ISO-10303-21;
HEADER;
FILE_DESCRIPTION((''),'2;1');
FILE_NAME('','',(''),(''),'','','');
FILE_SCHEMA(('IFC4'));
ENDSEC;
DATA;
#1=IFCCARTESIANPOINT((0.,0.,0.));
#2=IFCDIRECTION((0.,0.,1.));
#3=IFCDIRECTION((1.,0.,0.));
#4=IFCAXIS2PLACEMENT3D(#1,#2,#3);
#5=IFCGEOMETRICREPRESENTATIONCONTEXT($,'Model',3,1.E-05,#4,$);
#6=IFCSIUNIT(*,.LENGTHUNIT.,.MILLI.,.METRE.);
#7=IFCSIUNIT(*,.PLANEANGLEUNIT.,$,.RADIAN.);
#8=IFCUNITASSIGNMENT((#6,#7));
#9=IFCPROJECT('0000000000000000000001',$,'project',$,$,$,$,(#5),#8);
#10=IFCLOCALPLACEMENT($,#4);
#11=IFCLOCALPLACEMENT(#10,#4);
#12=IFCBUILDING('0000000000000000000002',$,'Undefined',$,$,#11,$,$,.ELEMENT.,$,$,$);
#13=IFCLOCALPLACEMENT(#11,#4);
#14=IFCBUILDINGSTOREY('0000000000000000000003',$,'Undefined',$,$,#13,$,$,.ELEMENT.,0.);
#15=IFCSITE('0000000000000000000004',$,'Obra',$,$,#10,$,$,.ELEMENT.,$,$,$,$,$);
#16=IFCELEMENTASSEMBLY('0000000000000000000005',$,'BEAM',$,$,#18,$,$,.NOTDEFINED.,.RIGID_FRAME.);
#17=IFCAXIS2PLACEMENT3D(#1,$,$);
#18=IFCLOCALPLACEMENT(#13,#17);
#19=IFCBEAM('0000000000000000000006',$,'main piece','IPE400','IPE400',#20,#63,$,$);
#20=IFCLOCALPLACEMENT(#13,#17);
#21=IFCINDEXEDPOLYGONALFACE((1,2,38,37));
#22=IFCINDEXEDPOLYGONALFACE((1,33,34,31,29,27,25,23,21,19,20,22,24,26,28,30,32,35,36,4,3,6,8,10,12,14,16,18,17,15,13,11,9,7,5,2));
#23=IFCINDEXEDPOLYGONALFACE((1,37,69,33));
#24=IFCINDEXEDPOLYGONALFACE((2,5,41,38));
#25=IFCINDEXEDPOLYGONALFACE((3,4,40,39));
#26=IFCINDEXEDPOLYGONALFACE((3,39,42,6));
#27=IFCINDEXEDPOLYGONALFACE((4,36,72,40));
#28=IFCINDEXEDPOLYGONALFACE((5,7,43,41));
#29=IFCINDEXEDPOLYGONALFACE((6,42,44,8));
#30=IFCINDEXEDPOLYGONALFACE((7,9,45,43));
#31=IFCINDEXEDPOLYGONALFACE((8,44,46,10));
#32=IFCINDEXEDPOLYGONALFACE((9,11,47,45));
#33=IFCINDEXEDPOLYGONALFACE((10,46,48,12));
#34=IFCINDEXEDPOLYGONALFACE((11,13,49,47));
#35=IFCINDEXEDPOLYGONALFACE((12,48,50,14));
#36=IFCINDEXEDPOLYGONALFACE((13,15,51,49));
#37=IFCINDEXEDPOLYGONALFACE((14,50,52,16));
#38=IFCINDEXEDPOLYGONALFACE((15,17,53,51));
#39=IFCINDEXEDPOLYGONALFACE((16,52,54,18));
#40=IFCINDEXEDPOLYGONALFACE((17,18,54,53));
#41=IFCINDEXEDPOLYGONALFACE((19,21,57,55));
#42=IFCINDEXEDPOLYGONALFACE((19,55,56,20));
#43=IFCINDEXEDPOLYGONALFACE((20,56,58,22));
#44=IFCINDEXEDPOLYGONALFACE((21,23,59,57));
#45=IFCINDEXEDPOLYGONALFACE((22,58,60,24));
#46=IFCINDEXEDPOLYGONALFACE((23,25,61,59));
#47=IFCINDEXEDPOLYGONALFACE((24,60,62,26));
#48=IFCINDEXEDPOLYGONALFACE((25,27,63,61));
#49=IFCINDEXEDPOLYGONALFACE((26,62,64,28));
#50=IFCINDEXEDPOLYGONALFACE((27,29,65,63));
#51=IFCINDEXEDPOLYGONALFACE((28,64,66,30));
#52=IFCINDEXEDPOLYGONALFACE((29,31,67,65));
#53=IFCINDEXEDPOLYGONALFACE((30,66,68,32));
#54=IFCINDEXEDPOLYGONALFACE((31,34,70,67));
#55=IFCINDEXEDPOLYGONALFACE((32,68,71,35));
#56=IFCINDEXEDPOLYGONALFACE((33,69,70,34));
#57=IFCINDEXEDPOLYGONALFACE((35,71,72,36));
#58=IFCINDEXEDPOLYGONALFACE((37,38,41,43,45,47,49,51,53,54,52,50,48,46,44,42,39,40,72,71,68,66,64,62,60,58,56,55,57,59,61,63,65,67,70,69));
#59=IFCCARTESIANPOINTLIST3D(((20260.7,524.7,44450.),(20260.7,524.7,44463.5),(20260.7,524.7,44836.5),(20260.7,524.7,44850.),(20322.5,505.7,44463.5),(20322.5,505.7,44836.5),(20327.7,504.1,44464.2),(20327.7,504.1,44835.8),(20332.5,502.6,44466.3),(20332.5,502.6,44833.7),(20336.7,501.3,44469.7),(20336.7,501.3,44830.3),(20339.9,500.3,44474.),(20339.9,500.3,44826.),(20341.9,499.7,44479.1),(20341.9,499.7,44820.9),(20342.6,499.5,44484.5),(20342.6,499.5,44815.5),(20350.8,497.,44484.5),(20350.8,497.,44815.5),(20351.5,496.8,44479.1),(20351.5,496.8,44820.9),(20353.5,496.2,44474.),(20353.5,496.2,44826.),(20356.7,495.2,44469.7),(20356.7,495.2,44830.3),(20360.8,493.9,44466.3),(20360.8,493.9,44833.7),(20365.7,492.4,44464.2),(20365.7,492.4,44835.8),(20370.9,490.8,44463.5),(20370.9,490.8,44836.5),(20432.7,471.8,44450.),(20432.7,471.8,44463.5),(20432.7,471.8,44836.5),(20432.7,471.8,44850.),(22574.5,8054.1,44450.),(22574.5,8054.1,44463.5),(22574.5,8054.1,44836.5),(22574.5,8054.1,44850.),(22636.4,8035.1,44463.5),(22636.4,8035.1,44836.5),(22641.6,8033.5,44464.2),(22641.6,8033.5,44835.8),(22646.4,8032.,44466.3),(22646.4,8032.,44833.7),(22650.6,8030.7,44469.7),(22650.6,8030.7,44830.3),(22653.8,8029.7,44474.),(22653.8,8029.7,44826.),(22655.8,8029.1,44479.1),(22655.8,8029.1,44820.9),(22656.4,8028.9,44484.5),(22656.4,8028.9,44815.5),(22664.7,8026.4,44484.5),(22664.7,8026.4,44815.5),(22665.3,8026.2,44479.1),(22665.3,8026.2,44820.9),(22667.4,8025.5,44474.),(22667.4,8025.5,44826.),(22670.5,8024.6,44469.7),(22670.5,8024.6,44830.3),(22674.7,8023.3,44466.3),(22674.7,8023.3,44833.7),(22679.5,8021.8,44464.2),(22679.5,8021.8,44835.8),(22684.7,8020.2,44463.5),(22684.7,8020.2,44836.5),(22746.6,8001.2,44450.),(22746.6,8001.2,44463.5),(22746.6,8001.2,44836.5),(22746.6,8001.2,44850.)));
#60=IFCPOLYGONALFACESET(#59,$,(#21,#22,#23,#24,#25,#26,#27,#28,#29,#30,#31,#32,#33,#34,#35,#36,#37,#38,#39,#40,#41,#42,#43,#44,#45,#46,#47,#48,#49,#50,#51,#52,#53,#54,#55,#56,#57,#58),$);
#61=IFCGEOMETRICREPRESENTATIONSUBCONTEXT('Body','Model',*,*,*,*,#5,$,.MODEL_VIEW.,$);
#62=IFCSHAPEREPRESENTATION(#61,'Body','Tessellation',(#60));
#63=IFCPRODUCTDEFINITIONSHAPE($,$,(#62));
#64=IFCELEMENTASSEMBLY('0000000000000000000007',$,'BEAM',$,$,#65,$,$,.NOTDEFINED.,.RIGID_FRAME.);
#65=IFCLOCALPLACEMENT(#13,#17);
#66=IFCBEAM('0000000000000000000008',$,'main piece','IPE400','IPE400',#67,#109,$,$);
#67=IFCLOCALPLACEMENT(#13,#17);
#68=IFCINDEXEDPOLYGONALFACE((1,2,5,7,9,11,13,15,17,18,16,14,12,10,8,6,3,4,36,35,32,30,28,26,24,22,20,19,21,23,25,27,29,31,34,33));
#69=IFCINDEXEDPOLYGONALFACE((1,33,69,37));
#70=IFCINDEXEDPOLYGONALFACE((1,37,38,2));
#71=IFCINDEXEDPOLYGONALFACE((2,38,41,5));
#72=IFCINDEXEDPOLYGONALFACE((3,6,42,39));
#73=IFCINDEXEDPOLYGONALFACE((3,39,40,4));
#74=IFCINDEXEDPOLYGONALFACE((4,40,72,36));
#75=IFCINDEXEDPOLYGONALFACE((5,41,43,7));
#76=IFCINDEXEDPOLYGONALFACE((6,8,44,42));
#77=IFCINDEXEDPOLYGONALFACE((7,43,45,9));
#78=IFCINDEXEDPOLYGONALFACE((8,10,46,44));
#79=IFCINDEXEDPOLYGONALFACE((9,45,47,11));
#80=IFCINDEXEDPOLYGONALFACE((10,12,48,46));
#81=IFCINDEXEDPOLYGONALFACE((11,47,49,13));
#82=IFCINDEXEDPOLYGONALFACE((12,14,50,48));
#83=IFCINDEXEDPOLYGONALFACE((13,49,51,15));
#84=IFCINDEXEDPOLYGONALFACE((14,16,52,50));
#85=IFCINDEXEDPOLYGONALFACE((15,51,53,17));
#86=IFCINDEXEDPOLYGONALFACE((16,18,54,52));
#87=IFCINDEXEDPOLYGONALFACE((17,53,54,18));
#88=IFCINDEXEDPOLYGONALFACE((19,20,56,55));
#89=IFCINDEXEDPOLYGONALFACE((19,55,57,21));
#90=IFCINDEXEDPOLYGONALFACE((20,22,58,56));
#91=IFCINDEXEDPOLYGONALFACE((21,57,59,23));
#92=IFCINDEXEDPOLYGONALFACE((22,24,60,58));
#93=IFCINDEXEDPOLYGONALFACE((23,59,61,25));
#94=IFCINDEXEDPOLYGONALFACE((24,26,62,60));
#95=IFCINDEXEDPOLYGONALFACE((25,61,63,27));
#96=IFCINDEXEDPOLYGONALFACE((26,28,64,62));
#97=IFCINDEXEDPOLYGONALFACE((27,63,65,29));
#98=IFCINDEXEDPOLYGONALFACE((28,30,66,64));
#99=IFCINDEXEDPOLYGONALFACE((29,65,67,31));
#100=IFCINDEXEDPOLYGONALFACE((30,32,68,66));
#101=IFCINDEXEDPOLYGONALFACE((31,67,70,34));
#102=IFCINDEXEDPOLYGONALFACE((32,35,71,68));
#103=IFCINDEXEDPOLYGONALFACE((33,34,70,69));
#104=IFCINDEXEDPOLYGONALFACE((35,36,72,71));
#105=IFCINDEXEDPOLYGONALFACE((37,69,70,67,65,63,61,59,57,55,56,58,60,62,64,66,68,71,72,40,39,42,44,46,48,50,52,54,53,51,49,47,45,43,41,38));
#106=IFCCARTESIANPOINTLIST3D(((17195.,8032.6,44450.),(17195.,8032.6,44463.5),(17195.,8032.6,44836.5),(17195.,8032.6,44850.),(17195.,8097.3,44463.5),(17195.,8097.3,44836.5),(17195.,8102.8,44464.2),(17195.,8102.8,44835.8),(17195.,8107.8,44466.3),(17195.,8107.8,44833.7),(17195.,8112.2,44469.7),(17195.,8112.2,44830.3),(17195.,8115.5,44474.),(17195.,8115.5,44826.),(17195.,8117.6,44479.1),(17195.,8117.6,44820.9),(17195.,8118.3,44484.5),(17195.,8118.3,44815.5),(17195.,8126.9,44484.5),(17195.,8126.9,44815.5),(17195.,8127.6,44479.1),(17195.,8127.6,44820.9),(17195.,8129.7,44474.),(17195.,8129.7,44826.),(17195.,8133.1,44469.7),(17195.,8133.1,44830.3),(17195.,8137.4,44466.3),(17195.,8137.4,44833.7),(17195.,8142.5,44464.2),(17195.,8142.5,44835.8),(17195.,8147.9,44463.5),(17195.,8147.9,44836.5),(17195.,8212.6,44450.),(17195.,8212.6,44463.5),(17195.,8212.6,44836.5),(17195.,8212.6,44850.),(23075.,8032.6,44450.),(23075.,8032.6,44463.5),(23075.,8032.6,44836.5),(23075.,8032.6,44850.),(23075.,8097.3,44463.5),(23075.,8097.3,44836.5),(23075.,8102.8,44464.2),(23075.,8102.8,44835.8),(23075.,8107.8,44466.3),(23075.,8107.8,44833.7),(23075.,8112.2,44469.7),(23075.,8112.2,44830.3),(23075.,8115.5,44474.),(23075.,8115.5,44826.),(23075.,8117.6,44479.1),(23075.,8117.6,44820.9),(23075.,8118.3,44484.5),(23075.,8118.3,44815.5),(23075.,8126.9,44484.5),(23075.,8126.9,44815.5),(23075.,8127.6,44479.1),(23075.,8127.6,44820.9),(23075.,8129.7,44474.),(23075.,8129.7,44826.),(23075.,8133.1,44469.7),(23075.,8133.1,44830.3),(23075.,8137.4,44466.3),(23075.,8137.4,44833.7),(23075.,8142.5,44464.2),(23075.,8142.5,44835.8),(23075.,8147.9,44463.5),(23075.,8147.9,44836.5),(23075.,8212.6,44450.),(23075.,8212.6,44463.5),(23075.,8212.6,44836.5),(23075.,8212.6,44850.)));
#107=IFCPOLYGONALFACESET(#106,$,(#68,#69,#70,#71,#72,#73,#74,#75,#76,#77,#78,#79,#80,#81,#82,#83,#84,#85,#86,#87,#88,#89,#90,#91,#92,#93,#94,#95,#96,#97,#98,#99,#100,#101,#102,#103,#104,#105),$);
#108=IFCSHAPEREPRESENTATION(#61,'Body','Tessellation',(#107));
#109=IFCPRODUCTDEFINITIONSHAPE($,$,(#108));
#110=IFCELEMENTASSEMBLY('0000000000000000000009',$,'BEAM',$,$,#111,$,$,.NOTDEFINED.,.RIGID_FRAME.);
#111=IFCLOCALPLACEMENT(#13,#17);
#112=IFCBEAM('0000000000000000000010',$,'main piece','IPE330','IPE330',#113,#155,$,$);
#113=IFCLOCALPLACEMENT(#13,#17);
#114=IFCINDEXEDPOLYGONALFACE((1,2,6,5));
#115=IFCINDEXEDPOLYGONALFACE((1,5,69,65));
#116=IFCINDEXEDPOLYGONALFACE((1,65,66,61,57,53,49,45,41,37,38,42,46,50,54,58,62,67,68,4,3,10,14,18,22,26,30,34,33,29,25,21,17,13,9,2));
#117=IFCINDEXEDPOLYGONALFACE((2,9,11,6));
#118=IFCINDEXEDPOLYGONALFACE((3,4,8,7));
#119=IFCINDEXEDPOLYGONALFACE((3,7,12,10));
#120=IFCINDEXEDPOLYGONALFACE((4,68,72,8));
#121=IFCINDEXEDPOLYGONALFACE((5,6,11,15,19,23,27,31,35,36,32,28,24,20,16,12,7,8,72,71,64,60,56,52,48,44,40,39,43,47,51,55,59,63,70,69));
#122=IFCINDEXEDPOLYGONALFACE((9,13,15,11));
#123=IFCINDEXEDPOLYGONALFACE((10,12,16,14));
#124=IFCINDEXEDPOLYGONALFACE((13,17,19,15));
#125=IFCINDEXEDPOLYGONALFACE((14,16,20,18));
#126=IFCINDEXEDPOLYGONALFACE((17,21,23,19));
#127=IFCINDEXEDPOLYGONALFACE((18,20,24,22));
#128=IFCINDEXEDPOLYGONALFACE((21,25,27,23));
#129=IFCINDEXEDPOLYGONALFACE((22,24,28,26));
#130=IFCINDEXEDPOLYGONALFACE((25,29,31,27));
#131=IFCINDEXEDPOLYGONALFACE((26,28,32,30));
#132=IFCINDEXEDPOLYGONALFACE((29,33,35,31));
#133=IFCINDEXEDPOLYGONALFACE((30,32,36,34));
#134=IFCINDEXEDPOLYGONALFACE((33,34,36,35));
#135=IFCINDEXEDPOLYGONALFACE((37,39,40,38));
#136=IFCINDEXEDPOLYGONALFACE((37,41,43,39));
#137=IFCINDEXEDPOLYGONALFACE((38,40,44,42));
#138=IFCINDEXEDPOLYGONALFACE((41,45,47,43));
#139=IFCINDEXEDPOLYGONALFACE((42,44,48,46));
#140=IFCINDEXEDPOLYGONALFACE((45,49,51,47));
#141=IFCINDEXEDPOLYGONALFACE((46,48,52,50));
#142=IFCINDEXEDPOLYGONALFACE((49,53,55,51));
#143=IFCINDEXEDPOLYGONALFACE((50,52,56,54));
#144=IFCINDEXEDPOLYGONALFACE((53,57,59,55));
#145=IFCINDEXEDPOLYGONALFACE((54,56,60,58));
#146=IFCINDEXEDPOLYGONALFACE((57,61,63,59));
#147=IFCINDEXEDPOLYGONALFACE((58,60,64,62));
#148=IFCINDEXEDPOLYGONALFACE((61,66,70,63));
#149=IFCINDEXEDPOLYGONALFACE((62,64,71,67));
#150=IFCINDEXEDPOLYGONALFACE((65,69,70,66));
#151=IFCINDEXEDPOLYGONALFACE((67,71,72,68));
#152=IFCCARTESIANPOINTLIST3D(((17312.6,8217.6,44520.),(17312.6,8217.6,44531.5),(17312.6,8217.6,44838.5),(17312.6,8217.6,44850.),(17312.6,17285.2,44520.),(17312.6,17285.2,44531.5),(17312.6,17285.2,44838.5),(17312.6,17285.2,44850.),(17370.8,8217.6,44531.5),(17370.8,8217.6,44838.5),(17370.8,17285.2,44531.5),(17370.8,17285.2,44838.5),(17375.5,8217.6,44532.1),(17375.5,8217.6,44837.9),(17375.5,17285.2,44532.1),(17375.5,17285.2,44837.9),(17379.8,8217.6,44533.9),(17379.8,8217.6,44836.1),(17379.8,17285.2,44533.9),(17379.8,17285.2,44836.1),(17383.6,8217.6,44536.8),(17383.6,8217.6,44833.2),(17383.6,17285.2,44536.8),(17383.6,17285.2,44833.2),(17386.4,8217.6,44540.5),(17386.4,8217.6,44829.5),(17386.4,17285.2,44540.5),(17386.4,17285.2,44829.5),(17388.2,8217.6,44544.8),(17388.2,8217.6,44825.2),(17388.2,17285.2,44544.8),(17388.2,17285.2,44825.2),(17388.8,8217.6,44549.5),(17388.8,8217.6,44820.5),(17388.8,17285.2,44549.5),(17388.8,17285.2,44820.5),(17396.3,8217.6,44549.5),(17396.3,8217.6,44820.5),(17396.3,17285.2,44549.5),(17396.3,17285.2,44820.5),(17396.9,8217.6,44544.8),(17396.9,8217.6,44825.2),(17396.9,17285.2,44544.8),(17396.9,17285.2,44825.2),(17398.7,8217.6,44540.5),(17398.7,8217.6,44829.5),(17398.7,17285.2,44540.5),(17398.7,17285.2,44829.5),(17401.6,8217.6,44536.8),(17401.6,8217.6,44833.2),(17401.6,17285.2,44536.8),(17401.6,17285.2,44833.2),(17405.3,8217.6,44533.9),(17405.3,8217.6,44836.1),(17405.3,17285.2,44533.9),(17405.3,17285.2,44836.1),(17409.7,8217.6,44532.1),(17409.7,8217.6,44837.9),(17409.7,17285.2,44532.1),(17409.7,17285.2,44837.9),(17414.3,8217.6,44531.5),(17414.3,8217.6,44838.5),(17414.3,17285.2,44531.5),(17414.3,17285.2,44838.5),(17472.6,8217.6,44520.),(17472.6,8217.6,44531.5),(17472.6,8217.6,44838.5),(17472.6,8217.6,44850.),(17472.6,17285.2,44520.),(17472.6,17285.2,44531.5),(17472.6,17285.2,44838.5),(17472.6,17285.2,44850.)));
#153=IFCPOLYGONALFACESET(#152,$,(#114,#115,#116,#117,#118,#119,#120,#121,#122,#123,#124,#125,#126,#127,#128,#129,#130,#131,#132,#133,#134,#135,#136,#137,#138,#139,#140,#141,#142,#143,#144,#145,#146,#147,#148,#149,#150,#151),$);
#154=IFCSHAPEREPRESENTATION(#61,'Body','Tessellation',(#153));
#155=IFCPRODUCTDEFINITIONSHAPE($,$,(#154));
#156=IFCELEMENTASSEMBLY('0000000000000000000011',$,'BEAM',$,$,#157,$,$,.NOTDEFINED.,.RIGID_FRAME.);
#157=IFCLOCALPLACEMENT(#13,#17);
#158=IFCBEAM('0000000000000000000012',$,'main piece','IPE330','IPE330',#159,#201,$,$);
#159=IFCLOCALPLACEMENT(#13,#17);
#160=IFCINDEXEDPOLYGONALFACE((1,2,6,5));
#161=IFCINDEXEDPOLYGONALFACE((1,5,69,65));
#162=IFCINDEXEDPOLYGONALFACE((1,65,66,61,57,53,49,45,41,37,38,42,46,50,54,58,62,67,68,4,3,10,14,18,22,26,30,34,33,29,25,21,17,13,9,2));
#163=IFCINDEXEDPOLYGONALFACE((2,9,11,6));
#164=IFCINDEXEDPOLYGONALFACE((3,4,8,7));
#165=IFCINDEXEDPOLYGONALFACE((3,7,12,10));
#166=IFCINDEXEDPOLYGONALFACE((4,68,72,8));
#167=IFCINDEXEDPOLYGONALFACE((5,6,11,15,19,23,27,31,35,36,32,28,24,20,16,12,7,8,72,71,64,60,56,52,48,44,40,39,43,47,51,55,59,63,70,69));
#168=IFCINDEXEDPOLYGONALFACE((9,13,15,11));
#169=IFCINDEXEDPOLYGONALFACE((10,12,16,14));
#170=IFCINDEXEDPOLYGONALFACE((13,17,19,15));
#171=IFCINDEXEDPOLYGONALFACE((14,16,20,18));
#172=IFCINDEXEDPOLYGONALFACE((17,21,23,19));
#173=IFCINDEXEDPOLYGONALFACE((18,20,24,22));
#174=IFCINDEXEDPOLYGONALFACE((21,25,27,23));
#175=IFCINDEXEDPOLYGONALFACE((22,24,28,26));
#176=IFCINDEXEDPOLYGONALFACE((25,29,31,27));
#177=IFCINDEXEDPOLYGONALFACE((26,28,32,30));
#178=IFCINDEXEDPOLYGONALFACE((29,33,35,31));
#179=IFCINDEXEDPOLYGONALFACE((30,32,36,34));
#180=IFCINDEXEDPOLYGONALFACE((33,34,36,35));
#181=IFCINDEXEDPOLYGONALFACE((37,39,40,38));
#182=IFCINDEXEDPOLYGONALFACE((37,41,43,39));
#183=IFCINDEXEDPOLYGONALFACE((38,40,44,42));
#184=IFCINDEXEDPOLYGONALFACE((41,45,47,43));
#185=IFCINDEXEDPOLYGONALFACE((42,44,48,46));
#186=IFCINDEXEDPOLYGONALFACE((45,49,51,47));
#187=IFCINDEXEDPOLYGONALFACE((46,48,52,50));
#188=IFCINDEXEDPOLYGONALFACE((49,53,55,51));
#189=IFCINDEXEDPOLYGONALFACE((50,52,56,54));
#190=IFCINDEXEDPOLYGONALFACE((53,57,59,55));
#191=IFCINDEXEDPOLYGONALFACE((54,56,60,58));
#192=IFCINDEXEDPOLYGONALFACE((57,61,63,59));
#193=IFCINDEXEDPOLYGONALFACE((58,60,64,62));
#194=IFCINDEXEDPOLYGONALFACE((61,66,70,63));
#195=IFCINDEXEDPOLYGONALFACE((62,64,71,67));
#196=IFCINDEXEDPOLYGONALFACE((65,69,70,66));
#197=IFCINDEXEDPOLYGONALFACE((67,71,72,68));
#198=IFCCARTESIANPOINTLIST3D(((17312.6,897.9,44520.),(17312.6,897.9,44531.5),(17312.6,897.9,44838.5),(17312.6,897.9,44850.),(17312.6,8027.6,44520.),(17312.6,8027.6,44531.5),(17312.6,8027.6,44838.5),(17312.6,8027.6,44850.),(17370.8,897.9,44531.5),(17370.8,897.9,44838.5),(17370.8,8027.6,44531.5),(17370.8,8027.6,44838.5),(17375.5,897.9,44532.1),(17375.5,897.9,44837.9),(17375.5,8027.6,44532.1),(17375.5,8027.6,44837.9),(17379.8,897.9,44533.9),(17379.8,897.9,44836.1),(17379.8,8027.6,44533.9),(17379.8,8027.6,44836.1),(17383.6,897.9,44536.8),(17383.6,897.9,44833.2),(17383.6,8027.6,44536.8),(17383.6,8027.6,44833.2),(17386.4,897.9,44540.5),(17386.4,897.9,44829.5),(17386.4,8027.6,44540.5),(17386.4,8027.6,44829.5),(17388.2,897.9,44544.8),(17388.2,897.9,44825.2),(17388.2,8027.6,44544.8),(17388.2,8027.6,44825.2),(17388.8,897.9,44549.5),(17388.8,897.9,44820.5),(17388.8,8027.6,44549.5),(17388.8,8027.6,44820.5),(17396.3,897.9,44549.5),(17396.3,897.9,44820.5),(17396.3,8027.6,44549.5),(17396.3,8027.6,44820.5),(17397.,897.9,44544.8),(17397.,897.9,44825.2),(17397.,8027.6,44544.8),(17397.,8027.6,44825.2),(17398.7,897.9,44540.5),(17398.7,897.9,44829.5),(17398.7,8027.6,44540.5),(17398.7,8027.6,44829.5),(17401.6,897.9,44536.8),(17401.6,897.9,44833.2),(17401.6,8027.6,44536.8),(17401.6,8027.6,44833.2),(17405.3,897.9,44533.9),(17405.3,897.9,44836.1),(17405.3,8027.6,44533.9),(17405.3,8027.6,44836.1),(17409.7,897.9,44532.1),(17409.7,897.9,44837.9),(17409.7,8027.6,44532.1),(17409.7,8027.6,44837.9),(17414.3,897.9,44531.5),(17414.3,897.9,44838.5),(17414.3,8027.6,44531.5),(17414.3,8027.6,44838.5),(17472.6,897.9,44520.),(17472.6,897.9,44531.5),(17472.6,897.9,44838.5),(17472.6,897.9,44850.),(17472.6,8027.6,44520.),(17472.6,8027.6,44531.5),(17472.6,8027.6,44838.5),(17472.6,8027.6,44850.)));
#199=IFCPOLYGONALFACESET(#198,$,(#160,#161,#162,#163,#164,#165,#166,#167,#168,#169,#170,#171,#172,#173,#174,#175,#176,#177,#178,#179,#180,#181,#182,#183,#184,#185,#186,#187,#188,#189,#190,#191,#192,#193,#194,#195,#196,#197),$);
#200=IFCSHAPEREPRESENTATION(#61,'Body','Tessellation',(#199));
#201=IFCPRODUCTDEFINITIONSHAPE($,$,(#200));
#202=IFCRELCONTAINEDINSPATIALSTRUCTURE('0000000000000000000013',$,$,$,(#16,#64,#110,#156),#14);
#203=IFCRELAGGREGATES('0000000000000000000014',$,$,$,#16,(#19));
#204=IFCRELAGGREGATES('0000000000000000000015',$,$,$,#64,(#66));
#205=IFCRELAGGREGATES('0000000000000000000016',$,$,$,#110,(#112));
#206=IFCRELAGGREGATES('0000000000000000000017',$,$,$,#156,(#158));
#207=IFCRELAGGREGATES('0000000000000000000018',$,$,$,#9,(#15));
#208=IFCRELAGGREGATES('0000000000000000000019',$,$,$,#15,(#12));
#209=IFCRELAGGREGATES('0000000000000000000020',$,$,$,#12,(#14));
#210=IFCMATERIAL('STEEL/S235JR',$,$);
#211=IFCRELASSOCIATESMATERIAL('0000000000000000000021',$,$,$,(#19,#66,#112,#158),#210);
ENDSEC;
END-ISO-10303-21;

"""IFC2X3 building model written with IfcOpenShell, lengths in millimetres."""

from ifc_helpers import new_model, si_unit, frame, origin_with_axes, origin_2d_with_axis, place, context, subcontext, project, spatial, i_section, extrude, material, element, aggregate, save


model = new_model("IFC2X3")

# Units and contexts
model_context = context("Model", 3, precision=1e-05, world=origin_with_axes())
body_context = subcontext(model_context, "Body", "Model", "MODEL_VIEW")
ifc_project = project(units=[si_unit("LENGTHUNIT", "METRE", prefix="MILLI"), si_unit("PLANEANGLEUNIT", "RADIAN")], contexts=[model_context])

# Site, building, storey
site_placement = place(None, origin_with_axes())
site = spatial("IfcSite", under=ifc_project, at=site_placement, Name="Obra", CompositionType="ELEMENT")
building_placement = place(site_placement, origin_with_axes())
building = spatial("IfcBuilding", under=site, at=building_placement, Name="Undefined", CompositionType="ELEMENT")
storey_placement = place(building_placement, origin_with_axes())
storey = spatial("IfcBuildingStorey", under=building, at=storey_placement, Name="Undefined", CompositionType="ELEMENT", Elevation=0.0)

# Shared definitions
ifc_material = material(Name="STEEL/S235JR")

# Element assemblies, beams
assembly_1_placement = place(storey_placement, origin_with_axes())
assembly_1 = element("IfcElementAssembly", 1, at=assembly_1_placement, inside=storey, Name="BEAM", AssemblyPlace="NOTDEFINED", PredefinedType="RIGID_FRAME")
beam_1_placement = place(assembly_1_placement, frame((20346.7, 498.2, 44650.0), z_axis=(0.0, 0.0, 1.0), x_axis=(0.293752, 0.955882, 0.0)))
beam_1 = element("IfcBeam", 2, at=beam_1_placement, material=ifc_material, Name="main piece", Description="IPE400", ObjectType="IPE400", context=body_context, shape_type="SweptSolid", body=[
    extrude(i_section(OverallWidth=180.0, OverallDepth=400.0, WebThickness=8.6, FlangeThickness=13.5, FilletRadius=21.0, at=origin_2d_with_axis()), frame((7876.9, 0.0, 0.0), z_axis=(-1.0, 0.0, 0.0), x_axis=(0.0, -1.0, 0.0)), (0.0, 0.0, 1.0), 7876.9),
])
aggregate(assembly_1, [beam_1])
assembly_2_placement = place(storey_placement, origin_with_axes())
assembly_2 = element("IfcElementAssembly", 3, at=assembly_2_placement, inside=storey, Name="BEAM", AssemblyPlace="NOTDEFINED", PredefinedType="RIGID_FRAME")
beam_2_placement = place(assembly_2_placement, frame((17195.0, 8122.6, 44650.0), z_axis=(0.0, 0.0, 1.0), x_axis=(1.0, 0.0, 0.0)))
beam_2 = element("IfcBeam", 4, at=beam_2_placement, material=ifc_material, Name="main piece", Description="IPE400", ObjectType="IPE400", context=body_context, shape_type="SweptSolid", body=[
    extrude(i_section(OverallWidth=180.0, OverallDepth=400.0, WebThickness=8.6, FlangeThickness=13.5, FilletRadius=21.0, at=origin_2d_with_axis()), frame((5880.0, 0.0, 0.0), z_axis=(-1.0, 0.0, 0.0), x_axis=(0.0, -1.0, 0.0)), (0.0, 0.0, 1.0), 5880.0),
])
aggregate(assembly_2, [beam_2])
assembly_3_placement = place(storey_placement, origin_with_axes())
assembly_3 = element("IfcElementAssembly", 5, at=assembly_3_placement, inside=storey, Name="BEAM", AssemblyPlace="NOTDEFINED", PredefinedType="RIGID_FRAME")
beam_3_placement = place(assembly_3_placement, frame((17392.6, 8217.6, 44685.0), z_axis=(0.0, 0.0, 1.0), x_axis=(0.0, 1.0, 0.0)))
beam_3 = element("IfcBeam", 6, at=beam_3_placement, material=ifc_material, Name="main piece", Description="IPE330", ObjectType="IPE330", context=body_context, shape_type="SweptSolid", body=[
    extrude(i_section(OverallWidth=160.0, OverallDepth=330.0, WebThickness=7.5, FlangeThickness=11.5, FilletRadius=18.0, at=origin_2d_with_axis()), frame((9067.6, 0.0, 0.0), z_axis=(-1.0, 0.0, 0.0), x_axis=(0.0, -1.0, 0.0)), (0.0, 0.0, 1.0), 9067.6),
])
aggregate(assembly_3, [beam_3])
assembly_4_placement = place(storey_placement, origin_with_axes())
assembly_4 = element("IfcElementAssembly", 7, at=assembly_4_placement, inside=storey, Name="BEAM", AssemblyPlace="NOTDEFINED", PredefinedType="RIGID_FRAME")
beam_4_placement = place(assembly_4_placement, frame((17392.6, 897.9, 44685.0), z_axis=(0.0, 0.0, 1.0), x_axis=(0.0, 1.0, 0.0)))
beam_4 = element("IfcBeam", 8, at=beam_4_placement, material=ifc_material, Name="main piece", Description="IPE330", ObjectType="IPE330", context=body_context, shape_type="SweptSolid", body=[
    extrude(i_section(OverallWidth=160.0, OverallDepth=330.0, WebThickness=7.5, FlangeThickness=11.5, FilletRadius=18.0, at=origin_2d_with_axis()), frame((7129.7, 0.0, 0.0), z_axis=(-1.0, 0.0, 0.0), x_axis=(0.0, -1.0, 0.0)), (0.0, 0.0, 1.0), 7129.7),
])
aggregate(assembly_4, [beam_4])

save(model, "model.ifc")
